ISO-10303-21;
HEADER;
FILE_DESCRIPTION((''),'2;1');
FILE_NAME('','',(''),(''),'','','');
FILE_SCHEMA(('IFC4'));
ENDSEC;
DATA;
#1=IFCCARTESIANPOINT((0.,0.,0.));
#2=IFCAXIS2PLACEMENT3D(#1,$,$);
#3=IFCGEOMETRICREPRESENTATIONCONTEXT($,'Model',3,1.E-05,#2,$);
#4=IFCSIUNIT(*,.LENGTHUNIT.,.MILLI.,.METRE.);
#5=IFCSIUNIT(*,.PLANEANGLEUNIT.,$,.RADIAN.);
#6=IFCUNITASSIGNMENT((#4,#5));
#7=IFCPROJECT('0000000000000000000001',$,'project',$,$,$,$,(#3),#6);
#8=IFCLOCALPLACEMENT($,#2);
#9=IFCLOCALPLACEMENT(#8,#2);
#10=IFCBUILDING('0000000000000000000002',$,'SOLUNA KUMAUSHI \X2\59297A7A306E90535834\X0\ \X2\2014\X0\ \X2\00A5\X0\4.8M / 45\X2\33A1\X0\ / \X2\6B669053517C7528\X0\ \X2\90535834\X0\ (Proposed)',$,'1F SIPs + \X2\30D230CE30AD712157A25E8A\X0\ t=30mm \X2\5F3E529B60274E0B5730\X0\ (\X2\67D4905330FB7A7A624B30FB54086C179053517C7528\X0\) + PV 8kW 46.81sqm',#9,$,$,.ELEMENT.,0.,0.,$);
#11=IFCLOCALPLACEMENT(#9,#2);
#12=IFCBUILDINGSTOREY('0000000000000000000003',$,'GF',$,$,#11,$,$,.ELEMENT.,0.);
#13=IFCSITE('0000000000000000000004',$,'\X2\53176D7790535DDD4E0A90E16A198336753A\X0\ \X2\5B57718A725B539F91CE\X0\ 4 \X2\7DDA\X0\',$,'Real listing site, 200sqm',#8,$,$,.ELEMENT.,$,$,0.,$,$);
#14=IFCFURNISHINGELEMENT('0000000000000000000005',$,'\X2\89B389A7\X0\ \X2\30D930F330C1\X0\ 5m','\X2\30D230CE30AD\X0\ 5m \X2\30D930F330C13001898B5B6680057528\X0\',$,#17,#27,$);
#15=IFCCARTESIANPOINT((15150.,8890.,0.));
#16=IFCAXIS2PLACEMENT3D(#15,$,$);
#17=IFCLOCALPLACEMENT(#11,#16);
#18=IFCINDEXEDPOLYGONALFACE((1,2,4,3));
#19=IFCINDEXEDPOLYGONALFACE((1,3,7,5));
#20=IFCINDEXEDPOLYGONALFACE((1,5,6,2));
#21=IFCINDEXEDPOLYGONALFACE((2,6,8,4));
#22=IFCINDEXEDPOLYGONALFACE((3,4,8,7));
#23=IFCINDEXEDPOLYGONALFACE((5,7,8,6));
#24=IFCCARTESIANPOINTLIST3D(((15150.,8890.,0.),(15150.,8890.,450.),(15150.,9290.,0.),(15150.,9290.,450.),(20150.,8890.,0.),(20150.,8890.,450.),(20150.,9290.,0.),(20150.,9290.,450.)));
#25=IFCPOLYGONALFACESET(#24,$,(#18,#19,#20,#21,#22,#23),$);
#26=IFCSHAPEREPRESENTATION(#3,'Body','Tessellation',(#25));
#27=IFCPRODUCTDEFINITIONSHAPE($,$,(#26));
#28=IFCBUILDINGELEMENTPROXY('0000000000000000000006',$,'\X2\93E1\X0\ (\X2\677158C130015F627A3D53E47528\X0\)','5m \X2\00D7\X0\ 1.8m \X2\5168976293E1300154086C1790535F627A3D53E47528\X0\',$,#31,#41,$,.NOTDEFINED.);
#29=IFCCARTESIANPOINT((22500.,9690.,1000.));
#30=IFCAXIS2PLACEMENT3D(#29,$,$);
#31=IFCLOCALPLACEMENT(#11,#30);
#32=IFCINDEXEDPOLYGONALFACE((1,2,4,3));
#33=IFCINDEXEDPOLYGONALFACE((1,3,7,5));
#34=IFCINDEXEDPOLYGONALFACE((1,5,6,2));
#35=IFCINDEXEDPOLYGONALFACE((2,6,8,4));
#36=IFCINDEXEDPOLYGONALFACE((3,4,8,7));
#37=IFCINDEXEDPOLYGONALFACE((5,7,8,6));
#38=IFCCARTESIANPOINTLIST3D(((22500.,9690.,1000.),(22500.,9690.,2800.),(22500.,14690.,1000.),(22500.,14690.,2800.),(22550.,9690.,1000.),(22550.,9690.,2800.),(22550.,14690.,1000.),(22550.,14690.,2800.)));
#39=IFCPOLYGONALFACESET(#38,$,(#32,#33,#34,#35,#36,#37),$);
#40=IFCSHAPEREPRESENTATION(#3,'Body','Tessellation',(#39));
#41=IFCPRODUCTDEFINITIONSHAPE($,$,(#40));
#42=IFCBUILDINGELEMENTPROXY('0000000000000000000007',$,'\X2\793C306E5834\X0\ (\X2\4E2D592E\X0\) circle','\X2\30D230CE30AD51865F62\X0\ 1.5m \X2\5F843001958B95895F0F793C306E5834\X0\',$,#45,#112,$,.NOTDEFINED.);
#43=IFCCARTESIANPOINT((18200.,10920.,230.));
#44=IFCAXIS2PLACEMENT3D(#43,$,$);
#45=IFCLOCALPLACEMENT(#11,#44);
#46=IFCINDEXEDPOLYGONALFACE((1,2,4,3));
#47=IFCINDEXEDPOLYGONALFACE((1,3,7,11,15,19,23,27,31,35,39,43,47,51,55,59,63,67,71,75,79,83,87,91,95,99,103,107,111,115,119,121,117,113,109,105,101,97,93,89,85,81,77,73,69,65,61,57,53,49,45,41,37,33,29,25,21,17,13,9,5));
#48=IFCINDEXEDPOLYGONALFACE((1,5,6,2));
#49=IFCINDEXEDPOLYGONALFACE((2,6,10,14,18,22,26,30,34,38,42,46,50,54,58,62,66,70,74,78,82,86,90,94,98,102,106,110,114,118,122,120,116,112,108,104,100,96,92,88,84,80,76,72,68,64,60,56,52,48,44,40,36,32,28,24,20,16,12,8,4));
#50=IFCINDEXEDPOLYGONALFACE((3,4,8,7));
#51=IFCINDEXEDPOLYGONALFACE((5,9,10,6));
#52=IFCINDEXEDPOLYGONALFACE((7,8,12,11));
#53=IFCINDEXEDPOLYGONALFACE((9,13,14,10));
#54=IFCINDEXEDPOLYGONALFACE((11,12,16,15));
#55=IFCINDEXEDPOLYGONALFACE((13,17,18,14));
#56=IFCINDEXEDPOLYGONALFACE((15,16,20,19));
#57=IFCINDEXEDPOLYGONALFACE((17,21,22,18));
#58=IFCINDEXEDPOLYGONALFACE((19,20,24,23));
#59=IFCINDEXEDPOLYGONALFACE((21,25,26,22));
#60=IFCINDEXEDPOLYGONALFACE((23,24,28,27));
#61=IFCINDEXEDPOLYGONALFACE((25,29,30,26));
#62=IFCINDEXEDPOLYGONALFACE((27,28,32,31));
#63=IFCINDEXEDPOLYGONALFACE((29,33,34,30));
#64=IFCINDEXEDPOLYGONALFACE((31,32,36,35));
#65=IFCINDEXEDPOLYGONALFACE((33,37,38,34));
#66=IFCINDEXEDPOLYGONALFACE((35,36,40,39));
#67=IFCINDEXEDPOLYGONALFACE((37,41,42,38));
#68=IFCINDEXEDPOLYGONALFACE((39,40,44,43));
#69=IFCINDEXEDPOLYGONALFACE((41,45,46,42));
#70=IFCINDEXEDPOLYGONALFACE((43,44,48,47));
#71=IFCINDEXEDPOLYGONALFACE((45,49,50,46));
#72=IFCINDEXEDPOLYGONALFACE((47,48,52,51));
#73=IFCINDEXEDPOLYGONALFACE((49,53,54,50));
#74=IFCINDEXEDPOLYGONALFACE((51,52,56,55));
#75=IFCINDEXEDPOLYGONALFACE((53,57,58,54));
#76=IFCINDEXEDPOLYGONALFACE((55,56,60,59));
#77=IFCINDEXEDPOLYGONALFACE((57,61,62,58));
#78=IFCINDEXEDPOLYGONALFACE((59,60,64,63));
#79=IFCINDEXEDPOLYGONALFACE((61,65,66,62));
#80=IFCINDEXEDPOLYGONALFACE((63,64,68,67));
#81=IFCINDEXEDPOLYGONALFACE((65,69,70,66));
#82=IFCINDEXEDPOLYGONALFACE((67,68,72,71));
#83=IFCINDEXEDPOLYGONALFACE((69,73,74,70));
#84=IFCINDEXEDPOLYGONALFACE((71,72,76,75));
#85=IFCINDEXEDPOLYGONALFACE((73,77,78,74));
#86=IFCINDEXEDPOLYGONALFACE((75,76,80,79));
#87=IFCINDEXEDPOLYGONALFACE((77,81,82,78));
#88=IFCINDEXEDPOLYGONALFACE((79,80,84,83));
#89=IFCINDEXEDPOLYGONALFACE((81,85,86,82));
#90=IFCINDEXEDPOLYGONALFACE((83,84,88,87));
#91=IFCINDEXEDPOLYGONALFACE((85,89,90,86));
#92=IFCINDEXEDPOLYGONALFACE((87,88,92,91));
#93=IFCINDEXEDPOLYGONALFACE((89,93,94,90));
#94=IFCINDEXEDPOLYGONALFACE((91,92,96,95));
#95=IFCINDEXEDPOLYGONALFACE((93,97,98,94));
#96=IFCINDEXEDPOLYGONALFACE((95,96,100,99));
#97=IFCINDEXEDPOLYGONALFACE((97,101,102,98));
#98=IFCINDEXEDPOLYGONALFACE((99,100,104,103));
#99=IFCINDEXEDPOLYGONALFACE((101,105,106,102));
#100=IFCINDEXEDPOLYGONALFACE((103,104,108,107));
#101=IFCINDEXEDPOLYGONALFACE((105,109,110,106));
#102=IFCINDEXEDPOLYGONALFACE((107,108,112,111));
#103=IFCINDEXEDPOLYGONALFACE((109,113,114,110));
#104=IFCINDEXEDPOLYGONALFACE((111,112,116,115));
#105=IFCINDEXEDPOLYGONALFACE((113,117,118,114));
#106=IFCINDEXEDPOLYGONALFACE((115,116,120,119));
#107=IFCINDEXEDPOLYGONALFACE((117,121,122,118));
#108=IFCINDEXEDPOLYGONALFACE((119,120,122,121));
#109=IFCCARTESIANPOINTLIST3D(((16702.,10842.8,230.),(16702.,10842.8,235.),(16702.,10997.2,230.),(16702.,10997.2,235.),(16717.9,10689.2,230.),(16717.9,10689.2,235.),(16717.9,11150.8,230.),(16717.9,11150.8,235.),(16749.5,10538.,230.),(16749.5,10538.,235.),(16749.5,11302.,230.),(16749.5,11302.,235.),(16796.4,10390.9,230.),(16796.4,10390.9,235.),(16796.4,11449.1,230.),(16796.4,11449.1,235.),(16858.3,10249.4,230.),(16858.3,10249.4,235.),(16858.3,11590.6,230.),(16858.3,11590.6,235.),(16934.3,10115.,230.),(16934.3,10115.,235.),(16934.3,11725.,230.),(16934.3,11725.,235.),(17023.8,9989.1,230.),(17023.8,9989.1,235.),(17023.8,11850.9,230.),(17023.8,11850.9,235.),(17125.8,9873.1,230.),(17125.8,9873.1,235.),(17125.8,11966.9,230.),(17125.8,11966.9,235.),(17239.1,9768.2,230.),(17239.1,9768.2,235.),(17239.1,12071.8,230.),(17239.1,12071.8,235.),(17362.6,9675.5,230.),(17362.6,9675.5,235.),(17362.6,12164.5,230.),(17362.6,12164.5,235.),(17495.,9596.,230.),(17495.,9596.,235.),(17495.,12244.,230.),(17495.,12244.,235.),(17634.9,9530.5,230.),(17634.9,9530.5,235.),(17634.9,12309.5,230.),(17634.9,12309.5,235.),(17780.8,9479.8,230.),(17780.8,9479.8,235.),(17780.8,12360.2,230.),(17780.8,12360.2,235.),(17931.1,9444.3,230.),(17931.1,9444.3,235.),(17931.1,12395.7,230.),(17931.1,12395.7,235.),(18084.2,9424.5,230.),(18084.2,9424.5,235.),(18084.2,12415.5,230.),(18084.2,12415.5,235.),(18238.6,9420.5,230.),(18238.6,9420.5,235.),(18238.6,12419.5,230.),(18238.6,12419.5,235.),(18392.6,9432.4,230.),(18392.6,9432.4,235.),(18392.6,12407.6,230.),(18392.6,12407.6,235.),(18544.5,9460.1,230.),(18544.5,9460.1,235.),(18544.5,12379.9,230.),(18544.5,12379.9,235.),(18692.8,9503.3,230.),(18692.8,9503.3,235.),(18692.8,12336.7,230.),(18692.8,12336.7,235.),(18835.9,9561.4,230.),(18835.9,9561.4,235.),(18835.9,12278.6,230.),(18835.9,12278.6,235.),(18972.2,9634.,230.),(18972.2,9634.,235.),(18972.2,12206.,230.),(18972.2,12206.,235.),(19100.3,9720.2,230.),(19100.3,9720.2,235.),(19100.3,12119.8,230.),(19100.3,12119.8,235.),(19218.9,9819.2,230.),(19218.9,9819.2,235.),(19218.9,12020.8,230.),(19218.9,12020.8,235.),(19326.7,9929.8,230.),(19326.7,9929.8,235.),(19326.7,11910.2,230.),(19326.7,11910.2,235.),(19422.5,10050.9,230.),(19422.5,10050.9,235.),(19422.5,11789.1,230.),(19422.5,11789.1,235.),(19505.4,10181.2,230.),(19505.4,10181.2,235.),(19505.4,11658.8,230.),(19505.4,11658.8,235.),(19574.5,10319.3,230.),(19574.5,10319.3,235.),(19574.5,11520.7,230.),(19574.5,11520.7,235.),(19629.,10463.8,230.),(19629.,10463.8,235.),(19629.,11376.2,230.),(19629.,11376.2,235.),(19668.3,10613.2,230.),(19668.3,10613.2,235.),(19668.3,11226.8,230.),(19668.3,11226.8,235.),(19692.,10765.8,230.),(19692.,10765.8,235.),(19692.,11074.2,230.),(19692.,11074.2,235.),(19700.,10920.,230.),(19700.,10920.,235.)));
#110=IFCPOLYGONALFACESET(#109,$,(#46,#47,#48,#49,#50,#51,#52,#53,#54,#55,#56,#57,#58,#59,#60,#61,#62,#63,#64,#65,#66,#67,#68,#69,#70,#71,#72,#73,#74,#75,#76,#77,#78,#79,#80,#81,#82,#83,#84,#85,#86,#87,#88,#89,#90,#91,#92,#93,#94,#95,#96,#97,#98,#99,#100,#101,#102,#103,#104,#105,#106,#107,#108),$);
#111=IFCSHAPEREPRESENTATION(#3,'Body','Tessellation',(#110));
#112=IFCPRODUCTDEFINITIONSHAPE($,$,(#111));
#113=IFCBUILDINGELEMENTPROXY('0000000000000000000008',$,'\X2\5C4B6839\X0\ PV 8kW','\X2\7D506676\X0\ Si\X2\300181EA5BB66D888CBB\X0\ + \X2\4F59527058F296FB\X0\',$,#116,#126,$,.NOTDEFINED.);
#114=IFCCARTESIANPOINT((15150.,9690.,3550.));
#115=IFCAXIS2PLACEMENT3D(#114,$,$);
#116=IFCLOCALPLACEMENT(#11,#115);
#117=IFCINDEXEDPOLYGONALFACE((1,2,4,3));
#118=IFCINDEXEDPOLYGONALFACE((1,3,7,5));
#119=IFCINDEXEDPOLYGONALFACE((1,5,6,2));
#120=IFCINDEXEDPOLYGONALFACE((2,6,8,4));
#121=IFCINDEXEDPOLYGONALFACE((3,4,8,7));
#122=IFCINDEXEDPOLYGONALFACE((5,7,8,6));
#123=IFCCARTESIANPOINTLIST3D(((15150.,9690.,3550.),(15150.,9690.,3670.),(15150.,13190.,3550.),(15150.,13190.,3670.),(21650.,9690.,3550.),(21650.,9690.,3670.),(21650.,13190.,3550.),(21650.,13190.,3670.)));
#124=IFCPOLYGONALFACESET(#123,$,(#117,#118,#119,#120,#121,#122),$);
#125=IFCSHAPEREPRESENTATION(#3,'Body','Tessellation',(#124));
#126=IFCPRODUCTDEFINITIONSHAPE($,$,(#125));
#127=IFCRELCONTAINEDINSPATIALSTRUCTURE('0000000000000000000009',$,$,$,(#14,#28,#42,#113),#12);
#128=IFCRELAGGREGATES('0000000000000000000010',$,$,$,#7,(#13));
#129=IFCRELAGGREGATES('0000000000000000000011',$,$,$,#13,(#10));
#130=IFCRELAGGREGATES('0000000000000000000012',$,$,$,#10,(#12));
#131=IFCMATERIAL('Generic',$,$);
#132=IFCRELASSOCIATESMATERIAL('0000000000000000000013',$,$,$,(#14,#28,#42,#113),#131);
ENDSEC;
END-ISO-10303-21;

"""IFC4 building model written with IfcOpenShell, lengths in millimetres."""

from ifc_helpers import new_model, si_unit, frame, frame_2d, origin, origin_2d, place, context, project, spatial, rectangle, circle, extrude, material, element, save


model = new_model("IFC4")

# Units and contexts
model_context = context("Model", 3, precision=1e-05, world=origin())
ifc_project = project(units=[si_unit("LENGTHUNIT", "METRE", prefix="MILLI"), si_unit("PLANEANGLEUNIT", "RADIAN")], contexts=[model_context])

# Site, building, storey
site_placement = place(None, origin())
site = spatial("IfcSite", under=ifc_project, at=site_placement, Name="北海道川上郡標茶町 字熊牛原野 4 線", ObjectType="Real listing site, 200sqm", CompositionType="ELEMENT", RefElevation=0.0)
building_placement = place(site_placement, origin())
building = spatial("IfcBuilding", under=site, at=building_placement, Name="SOLUNA KUMAUSHI 天空の道場 — ¥4.8M / 45㎡ / 武道兼用 道場 (Proposed)", ObjectType="1F SIPs + ヒノキ無垢床 t=30mm 弾力性下地 (柔道・空手・合気道兼用) + PV 8kW 46.81sqm", CompositionType="ELEMENT", ElevationOfRefHeight=0.0, ElevationOfTerrain=0.0)
storey_placement = place(building_placement, origin())
storey = spatial("IfcBuildingStorey", under=building, at=storey_placement, Name="GF", CompositionType="ELEMENT", Elevation=0.0)

# Shared definitions
ifc_material = material(Name="Generic")

# Furnishing element
furnishing_1_placement = place(storey_placement, frame((15150.0, 8890.0, 0.0)))
element("IfcFurnishingElement", 1, at=furnishing_1_placement, inside=storey, material=ifc_material, Name="観覧 ベンチ 5m", Description="ヒノキ 5m ベンチ、見学者用", context=model_context, shape_type="SweptSolid", body=[
    extrude(rectangle(XDim=5000.0, YDim=400.0, at=frame_2d((2500.0, 200.0))), frame((15150.0, 8890.0, 0.0)), (0.0, 0.0, 1.0), 450.0),
])

# Building element proxies
proxy_1_placement = place(storey_placement, frame((22500.0, 9690.0, 1000.0)))
element("IfcBuildingElementProxy", 2, at=proxy_1_placement, inside=storey, material=ifc_material, Name="鏡 (東壁、形稽古用)", Description="5m × 1.8m 全面鏡、合気道形稽古用", PredefinedType="NOTDEFINED", context=model_context, shape_type="SweptSolid", body=[
    extrude(rectangle(XDim=50.0, YDim=5000.0, at=frame_2d((25.0, 2500.0))), frame((22500.0, 9690.0, 1000.0)), (0.0, 0.0, 1.0), 1800.0),
])
proxy_2_placement = place(storey_placement, frame((18200.0, 10920.0, 230.0)))
element("IfcBuildingElementProxy", 3, at=proxy_2_placement, inside=storey, material=ifc_material, Name="礼の場 (中央) circle", Description="ヒノキ円形 1.5m 径、開閉式礼の場", PredefinedType="NOTDEFINED", context=model_context, shape_type="SweptSolid", body=[
    extrude(circle(Radius=1500.0, at=origin_2d()), frame((18200.0, 10920.0, 230.0)), (0.0, 0.0, 1.0), 5.0),
])
proxy_3_placement = place(storey_placement, frame((15150.0, 9690.0, 3550.0)))
element("IfcBuildingElementProxy", 4, at=proxy_3_placement, inside=storey, material=ifc_material, Name="屋根 PV 8kW", Description="結晶 Si、自家消費 + 余剰売電", PredefinedType="NOTDEFINED", context=model_context, shape_type="SweptSolid", body=[
    extrude(rectangle(XDim=6500.0, YDim=3500.0, at=frame_2d((3250.0, 1750.0))), frame((15150.0, 9690.0, 3550.0)), (0.0, 0.0, 1.0), 120.0),
])

save(model, "model.ifc")
